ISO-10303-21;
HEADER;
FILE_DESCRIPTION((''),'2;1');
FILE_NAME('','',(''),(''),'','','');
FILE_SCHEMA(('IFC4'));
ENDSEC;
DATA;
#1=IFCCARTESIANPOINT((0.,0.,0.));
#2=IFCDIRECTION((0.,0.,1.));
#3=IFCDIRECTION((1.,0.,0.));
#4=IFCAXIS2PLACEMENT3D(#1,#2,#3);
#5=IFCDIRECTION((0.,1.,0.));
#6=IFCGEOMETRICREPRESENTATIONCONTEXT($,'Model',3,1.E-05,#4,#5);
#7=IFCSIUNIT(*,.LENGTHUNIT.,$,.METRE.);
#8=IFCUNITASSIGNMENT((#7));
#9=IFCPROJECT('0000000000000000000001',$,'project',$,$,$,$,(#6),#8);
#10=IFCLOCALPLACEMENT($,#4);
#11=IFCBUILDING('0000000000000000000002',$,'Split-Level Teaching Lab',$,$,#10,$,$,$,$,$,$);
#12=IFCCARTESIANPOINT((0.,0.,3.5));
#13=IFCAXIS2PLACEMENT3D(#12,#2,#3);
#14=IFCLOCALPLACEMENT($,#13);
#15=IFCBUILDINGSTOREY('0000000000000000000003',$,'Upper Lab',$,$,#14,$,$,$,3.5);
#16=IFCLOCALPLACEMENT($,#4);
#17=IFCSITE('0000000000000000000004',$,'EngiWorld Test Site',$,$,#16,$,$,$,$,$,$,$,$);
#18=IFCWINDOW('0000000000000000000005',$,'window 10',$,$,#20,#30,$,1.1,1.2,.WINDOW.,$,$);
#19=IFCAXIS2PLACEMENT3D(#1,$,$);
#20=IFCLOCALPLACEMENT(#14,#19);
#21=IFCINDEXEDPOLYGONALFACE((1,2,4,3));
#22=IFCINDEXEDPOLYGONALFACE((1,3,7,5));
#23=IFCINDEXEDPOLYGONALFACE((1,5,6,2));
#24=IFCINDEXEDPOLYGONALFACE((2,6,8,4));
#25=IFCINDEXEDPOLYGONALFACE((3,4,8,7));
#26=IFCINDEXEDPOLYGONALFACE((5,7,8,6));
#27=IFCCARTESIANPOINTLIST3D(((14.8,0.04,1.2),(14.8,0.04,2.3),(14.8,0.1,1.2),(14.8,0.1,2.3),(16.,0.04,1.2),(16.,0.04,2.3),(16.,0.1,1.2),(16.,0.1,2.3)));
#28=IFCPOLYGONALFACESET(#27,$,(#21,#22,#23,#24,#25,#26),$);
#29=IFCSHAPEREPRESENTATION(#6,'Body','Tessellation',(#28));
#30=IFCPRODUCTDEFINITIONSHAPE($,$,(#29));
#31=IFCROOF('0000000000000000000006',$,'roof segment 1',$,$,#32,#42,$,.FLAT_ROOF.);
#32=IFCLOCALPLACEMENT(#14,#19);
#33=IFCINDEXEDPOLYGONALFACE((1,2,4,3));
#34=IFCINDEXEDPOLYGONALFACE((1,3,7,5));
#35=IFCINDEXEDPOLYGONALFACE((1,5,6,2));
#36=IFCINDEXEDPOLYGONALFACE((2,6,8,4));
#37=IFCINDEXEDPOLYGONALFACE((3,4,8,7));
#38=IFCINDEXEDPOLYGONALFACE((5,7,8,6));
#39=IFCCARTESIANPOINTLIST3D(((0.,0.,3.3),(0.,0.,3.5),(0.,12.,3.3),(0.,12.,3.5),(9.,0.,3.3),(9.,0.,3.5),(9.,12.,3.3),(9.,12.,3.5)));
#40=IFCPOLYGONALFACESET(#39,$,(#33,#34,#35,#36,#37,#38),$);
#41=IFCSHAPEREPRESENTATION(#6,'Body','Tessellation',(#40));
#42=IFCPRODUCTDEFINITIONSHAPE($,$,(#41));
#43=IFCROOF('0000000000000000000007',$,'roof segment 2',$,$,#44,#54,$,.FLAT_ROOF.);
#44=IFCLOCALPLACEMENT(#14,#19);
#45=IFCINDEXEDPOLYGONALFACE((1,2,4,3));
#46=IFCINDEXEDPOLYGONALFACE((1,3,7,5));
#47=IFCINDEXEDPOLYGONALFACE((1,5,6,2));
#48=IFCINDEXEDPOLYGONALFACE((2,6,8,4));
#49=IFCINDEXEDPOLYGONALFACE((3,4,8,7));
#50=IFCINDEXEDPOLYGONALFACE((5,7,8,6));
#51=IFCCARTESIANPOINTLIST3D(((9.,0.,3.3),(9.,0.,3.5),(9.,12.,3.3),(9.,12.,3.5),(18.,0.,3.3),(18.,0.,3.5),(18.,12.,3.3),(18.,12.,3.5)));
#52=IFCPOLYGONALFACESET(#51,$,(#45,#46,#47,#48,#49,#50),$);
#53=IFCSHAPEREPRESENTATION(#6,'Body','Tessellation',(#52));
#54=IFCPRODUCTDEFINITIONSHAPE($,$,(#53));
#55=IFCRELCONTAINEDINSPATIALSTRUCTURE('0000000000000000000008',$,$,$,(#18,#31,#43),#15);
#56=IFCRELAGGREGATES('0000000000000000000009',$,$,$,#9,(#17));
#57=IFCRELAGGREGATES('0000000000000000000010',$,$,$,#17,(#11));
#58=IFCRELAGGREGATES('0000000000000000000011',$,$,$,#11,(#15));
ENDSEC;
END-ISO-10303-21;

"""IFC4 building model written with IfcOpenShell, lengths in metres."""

from ifc_helpers import new_model, si_unit, direction, frame, origin_with_axes, origin_2d_with_axis, place, context, project, spatial, rectangle, extrude, element, save


model = new_model("IFC4")

# Units and contexts
model_context = context("Model", 3, precision=1e-05, world=origin_with_axes(), true_north=direction((0.0, 1.0, 0.0)))
ifc_project = project(units=[si_unit("LENGTHUNIT", "METRE")], contexts=[model_context])

# Site, building, storey
site_placement = place(None, origin_with_axes())
site = spatial("IfcSite", under=ifc_project, at=site_placement, Name="EngiWorld Test Site")
building_placement = place(None, origin_with_axes())
building = spatial("IfcBuilding", under=site, at=building_placement, Name="Split-Level Teaching Lab")
storey_placement = place(None, frame((0.0, 0.0, 3.5), z_axis=(0.0, 0.0, 1.0), x_axis=(1.0, 0.0, 0.0)))
storey = spatial("IfcBuildingStorey", under=building, at=storey_placement, Name="Upper Lab", Elevation=3.5)

# Window
for number, where, z_axis, x_axis, name in (
    (1, (15.4, 0.07, 4.7), (0.0, 0.0, 1.0), (1.0, 0.0, 0.0), "window 10"),
):
    element("IfcWindow", number, at=place(None, frame(where, z_axis=z_axis, x_axis=x_axis)), inside=storey, Name=name, OverallHeight=1.1, OverallWidth=1.2, PredefinedType="WINDOW", context=model_context, shape_type="SweptSolid", body=[
        extrude(rectangle(XDim=1.2, YDim=0.06, at=origin_2d_with_axis()), origin_with_axes(), (0.0, 0.0, 1.0), 1.1),
    ])

# Roofs
for number, where, z_axis, x_axis, name in (
    (2, (4.5, 6.0, 6.8), (0.0, 0.0, 1.0), (1.0, 0.0, 0.0), "roof segment 1"),
    (3, (13.5, 6.0, 6.8), (0.0, 0.0, 1.0), (1.0, 0.0, 0.0), "roof segment 2"),
):
    element("IfcRoof", number, at=place(None, frame(where, z_axis=z_axis, x_axis=x_axis)), inside=storey, Name=name, PredefinedType="FLAT_ROOF", context=model_context, shape_type="SweptSolid", body=[
        extrude(rectangle(XDim=9.0, YDim=12.0, at=origin_2d_with_axis()), origin_with_axes(), (0.0, 0.0, 1.0), 0.2),
    ])

save(model, "model.ifc")
